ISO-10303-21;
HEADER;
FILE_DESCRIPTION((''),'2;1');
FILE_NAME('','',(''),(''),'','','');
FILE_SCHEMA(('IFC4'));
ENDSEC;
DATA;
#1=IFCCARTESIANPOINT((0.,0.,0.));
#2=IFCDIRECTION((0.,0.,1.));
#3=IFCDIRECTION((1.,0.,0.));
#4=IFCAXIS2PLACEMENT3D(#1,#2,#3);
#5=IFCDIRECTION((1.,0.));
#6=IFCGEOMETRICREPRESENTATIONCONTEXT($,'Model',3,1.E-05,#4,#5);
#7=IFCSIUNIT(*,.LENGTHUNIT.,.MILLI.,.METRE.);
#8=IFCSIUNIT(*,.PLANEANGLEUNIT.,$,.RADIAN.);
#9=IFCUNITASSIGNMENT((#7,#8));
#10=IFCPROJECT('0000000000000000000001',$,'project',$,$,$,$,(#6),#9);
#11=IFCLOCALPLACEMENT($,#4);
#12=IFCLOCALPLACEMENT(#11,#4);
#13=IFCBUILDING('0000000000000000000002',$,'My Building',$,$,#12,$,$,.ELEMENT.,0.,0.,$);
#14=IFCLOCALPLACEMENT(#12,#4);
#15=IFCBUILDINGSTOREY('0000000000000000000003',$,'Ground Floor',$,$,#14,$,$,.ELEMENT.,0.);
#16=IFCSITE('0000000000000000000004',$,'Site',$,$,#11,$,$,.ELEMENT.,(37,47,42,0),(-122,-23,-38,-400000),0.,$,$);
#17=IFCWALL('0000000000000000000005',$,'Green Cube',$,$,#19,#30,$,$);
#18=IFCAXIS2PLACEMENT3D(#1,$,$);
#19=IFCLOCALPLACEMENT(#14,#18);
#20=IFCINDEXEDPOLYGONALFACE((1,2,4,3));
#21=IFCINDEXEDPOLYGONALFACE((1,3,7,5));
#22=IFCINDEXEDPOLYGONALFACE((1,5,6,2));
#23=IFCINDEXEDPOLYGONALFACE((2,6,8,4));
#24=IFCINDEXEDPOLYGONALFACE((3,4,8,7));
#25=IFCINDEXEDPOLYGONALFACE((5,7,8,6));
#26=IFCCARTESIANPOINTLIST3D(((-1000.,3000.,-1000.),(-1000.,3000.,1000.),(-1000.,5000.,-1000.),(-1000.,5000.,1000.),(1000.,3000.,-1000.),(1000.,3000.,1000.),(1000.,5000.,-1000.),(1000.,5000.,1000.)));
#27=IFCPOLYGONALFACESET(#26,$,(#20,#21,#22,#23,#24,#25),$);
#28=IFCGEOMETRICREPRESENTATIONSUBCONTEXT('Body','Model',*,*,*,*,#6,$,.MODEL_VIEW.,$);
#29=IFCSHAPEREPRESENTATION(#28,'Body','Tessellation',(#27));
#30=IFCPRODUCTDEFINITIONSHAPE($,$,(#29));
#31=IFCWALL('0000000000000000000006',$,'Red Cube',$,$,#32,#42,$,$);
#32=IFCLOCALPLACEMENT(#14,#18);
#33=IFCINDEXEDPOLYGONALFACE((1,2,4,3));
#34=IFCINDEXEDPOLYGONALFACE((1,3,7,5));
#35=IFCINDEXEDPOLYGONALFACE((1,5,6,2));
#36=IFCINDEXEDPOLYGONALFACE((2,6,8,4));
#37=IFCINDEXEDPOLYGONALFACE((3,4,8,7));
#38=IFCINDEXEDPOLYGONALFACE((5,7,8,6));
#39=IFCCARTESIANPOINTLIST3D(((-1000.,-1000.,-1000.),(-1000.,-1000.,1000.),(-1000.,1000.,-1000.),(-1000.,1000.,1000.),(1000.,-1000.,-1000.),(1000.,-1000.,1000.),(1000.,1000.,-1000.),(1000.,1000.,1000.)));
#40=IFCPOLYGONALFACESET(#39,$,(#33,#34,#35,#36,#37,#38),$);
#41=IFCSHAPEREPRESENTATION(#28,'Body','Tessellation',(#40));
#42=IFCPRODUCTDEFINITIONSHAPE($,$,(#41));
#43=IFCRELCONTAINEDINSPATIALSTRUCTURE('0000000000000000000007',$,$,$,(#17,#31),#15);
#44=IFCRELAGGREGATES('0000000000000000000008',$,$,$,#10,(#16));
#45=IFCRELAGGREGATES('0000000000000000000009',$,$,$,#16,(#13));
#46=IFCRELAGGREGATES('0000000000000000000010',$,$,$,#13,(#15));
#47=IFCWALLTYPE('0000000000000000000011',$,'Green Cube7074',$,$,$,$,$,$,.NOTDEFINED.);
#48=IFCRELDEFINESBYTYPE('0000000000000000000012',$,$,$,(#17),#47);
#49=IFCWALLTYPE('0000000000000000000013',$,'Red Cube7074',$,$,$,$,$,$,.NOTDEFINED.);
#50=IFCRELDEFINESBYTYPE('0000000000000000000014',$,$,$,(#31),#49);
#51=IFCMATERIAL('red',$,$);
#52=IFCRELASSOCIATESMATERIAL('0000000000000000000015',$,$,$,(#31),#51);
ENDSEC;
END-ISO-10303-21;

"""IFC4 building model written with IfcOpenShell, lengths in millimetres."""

from ifc_helpers import new_model, si_unit, direction, frame, frame_2d, origin_with_axes, origin_2d_with_axis, place, context, subcontext, project, spatial, rectangle, extrude, source, transform, mapped, material, type_object, type_shapes, element, save


model = new_model("IFC4")

# Units and contexts
model_context = context("Model", 3, precision=1e-05, world=origin_with_axes(), true_north=direction((1.0, 0.0)))
body_context = subcontext(model_context, "Body", "Model", "MODEL_VIEW")
ifc_project = project(units=[si_unit("LENGTHUNIT", "METRE", prefix="MILLI"), si_unit("PLANEANGLEUNIT", "RADIAN")], contexts=[model_context])

# Site, building, storey
site_placement = place(None, origin_with_axes())
site = spatial("IfcSite", under=ifc_project, at=site_placement, Name="Site", CompositionType="ELEMENT", RefLatitude=(37, 47, 42, 0), RefLongitude=(-122, -23, -38, -400000), RefElevation=0.0)
building_placement = place(site_placement, origin_with_axes())
building = spatial("IfcBuilding", under=site, at=building_placement, Name="My Building", CompositionType="ELEMENT", ElevationOfRefHeight=0.0, ElevationOfTerrain=0.0)
storey_placement = place(building_placement, origin_with_axes())
storey = spatial("IfcBuildingStorey", under=building, at=storey_placement, Name="Ground Floor", CompositionType="ELEMENT", Elevation=0.0)

# Walls
wall_type_1 = type_object("IfcWallType", Name="Green Cube7074", PredefinedType="NOTDEFINED")
shared_shape_1 = source(origin_with_axes(), body_context, "Body", "SweptSolid", [
    extrude(rectangle(XDim=2000.0, YDim=2000.0, at=origin_2d_with_axis()), frame((0.0, 0.0, -1000.0), z_axis=(0.0, 0.0, 1.0), x_axis=(1.0, 0.0, 0.0)), (0.0, 0.0, 1.0), 2000.0),
])
type_shapes(wall_type_1, [shared_shape_1])
wall_1_placement = place(storey_placement, frame((0.0, 4000.0, 0.0), z_axis=(0.0, 0.0, 1.0), x_axis=(1.0, 0.0, 0.0)))
element("IfcWall", 1, at=wall_1_placement, inside=storey, type_object=wall_type_1, Name="Green Cube", context=body_context, shape_type="MappedRepresentation", body=[
    mapped(shared_shape_1, transform((0.0, 0.0, 0.0), x_axis=(1.0, 0.0, 0.0), y_axis=(0.0, 1.0, 0.0), z_axis=(0.0, 0.0, 1.0), scale=1.0)),
])
ifc_material = material(Name="red")
wall_type_2 = type_object("IfcWallType", Name="Red Cube7074", PredefinedType="NOTDEFINED")
shared_shape_2 = source(origin_with_axes(), body_context, "Body", "SweptSolid", [
    extrude(rectangle(XDim=2000.0, YDim=2000.0, at=frame_2d((0.0, 0.0), x_axis=(0.0, 1.0))), frame((0.0, 0.0, -1000.0), z_axis=(0.0, 0.0, 1.0), x_axis=(1.0, 0.0, 0.0)), (0.0, 0.0, 1.0), 2000.0),
])
type_shapes(wall_type_2, [shared_shape_2])
wall_2_placement = place(storey_placement, origin_with_axes())
element("IfcWall", 2, at=wall_2_placement, inside=storey, type_object=wall_type_2, material=ifc_material, Name="Red Cube", context=body_context, shape_type="MappedRepresentation", body=[
    mapped(shared_shape_2, transform((0.0, 0.0, 0.0), x_axis=(1.0, 0.0, 0.0), y_axis=(0.0, 1.0, 0.0), z_axis=(0.0, 0.0, 1.0), scale=1.0)),
])

save(model, "model.ifc")
